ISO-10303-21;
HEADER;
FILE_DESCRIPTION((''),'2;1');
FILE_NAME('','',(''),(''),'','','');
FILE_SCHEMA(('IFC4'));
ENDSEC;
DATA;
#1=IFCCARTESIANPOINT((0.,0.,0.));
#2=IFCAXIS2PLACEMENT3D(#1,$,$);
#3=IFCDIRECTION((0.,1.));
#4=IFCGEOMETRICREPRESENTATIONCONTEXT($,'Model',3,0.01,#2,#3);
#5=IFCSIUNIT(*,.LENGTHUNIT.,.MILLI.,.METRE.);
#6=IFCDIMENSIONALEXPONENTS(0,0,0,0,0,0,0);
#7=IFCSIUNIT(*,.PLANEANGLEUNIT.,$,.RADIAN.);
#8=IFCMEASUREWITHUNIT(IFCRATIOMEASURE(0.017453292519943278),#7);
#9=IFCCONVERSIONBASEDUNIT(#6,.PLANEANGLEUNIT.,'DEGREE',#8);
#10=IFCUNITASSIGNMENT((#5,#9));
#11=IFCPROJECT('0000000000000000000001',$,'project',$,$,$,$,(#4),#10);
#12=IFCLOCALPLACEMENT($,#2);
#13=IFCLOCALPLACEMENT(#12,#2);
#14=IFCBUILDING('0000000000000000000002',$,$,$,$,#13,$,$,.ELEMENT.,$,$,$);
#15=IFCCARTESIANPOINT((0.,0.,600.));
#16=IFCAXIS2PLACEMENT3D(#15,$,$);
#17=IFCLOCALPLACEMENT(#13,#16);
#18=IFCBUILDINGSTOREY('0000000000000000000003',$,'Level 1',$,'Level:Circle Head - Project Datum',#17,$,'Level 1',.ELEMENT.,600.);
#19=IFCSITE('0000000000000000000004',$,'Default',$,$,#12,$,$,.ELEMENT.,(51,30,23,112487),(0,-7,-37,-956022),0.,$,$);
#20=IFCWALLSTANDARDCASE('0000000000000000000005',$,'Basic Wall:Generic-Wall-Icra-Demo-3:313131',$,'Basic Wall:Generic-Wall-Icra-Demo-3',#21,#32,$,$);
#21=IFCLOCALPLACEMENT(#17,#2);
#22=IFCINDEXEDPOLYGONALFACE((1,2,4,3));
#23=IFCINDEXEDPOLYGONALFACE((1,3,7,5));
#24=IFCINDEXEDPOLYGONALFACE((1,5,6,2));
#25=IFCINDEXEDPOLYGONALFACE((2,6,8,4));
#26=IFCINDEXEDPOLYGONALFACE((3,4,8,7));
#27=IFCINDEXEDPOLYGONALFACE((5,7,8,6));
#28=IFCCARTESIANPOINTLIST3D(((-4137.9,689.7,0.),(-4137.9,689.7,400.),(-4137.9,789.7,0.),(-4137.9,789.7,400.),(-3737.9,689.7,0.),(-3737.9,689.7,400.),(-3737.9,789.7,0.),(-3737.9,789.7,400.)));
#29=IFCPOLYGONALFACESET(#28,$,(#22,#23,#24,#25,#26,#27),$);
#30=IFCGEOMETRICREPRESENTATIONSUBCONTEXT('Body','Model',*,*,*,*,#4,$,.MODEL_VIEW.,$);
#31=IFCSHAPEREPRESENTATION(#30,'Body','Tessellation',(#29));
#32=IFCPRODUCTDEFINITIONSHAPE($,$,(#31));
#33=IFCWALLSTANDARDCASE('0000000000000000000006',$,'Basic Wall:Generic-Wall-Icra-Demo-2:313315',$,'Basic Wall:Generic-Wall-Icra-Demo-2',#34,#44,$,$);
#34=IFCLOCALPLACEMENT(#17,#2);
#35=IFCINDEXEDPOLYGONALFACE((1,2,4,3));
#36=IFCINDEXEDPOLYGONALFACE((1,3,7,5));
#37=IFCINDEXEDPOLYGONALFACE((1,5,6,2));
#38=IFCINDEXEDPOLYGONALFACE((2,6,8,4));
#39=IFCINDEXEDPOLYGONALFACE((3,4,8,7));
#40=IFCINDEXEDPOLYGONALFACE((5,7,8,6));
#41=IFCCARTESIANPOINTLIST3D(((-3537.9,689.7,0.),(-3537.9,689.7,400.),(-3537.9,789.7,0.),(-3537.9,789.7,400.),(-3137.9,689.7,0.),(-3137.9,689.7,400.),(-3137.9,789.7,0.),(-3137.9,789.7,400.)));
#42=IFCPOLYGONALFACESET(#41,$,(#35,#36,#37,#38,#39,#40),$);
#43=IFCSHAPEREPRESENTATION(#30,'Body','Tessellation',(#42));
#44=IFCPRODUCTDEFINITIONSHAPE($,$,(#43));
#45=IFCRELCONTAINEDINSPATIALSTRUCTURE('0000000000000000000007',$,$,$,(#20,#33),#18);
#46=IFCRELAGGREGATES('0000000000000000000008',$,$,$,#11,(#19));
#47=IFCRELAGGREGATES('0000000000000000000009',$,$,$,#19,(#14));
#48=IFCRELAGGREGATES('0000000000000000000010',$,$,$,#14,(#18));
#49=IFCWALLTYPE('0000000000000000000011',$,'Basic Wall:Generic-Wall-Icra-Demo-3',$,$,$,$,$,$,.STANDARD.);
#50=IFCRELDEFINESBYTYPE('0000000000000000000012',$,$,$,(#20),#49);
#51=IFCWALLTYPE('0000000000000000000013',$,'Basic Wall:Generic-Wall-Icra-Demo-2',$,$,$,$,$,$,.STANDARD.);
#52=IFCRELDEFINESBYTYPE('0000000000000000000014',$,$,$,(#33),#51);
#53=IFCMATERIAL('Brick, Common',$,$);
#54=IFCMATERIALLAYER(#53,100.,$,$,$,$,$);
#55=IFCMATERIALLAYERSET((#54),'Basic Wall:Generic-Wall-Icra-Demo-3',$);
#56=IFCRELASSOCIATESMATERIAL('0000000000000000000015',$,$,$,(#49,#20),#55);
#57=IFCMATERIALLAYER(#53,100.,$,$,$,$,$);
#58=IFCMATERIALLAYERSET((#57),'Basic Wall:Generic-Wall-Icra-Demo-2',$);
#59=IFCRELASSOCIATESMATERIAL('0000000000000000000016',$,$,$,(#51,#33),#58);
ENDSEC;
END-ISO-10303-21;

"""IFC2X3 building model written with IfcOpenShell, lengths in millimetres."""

from ifc_helpers import new_model, entity, si_unit, converted_unit, direction, frame, frame_2d, origin, place, context, subcontext, project, spatial, rectangle, extrude, material, layer, layer_set, layer_usage, type_object, element, save


model = new_model("IFC2X3")

# Units and contexts
model_context = context("Model", 3, precision=0.01, world=origin(), true_north=direction((0.0, 1.0)))
body_context = subcontext(model_context, "Body", "Model", "MODEL_VIEW")
ifc_project = project(units=[si_unit("LENGTHUNIT", "METRE", prefix="MILLI"), converted_unit("PLANEANGLEUNIT", "DEGREE", entity("IfcRatioMeasure", 0.017453292519943278), si_unit("PLANEANGLEUNIT", "RADIAN"), dimensions=[0, 0, 0, 0, 0, 0, 0])], contexts=[model_context])

# Site, building, storey
site_placement = place(None, origin())
site = spatial("IfcSite", under=ifc_project, at=site_placement, Name="Default", CompositionType="ELEMENT", RefLatitude=(51, 30, 23, 112487), RefLongitude=(0, -7, -37, -956022), RefElevation=0.0)
building_placement = place(site_placement, origin())
building = spatial("IfcBuilding", under=site, at=building_placement, CompositionType="ELEMENT")
storey_placement = place(building_placement, frame((0.0, 0.0, 600.0)))
storey = spatial("IfcBuildingStorey", under=building, at=storey_placement, Name="Level 1", ObjectType="Level:Circle Head - Project Datum", LongName="Level 1", CompositionType="ELEMENT", Elevation=600.0)

# Walls
ifc_material = material(Name="Brick, Common")
ifc_layer_1 = layer(ifc_material, 100.0)
ifc_layer_set_1 = layer_set([ifc_layer_1], Name="Basic Wall:Generic-Wall-Icra-Demo-3")
ifc_layer_usage_1 = layer_usage(ifc_layer_set_1, "AXIS2", "NEGATIVE", 50.0)
wall_type_1 = type_object("IfcWallType", Name="Basic Wall:Generic-Wall-Icra-Demo-3", PredefinedType="STANDARD", material=ifc_layer_set_1)
wall_1_placement = place(storey_placement, frame((-4137.9, 739.7, 0.0)))
element("IfcWallStandardCase", 1, at=wall_1_placement, inside=storey, type_object=wall_type_1, material=ifc_layer_usage_1, Name="Basic Wall:Generic-Wall-Icra-Demo-3:313131", ObjectType="Basic Wall:Generic-Wall-Icra-Demo-3", context=body_context, shape_type="SweptSolid", body=[
    extrude(rectangle(XDim=400.0, YDim=100.0, at=frame_2d((200.0, 0.0), x_axis=(-1.0, 0.0))), origin(), (0.0, 0.0, 1.0), 400.0),
])
ifc_layer_2 = layer(ifc_material, 100.0)
ifc_layer_set_2 = layer_set([ifc_layer_2], Name="Basic Wall:Generic-Wall-Icra-Demo-2")
ifc_layer_usage_2 = layer_usage(ifc_layer_set_2, "AXIS2", "NEGATIVE", 50.0)
wall_type_2 = type_object("IfcWallType", Name="Basic Wall:Generic-Wall-Icra-Demo-2", PredefinedType="STANDARD", material=ifc_layer_set_2)
wall_2_placement = place(storey_placement, frame((-3537.9, 739.7, 0.0)))
element("IfcWallStandardCase", 2, at=wall_2_placement, inside=storey, type_object=wall_type_2, material=ifc_layer_usage_2, Name="Basic Wall:Generic-Wall-Icra-Demo-2:313315", ObjectType="Basic Wall:Generic-Wall-Icra-Demo-2", context=body_context, shape_type="SweptSolid", body=[
    extrude(rectangle(XDim=400.0, YDim=100.0, at=frame_2d((200.0, 0.0), x_axis=(-1.0, 0.0))), origin(), (0.0, 0.0, 1.0), 400.0),
])

save(model, "model.ifc")
